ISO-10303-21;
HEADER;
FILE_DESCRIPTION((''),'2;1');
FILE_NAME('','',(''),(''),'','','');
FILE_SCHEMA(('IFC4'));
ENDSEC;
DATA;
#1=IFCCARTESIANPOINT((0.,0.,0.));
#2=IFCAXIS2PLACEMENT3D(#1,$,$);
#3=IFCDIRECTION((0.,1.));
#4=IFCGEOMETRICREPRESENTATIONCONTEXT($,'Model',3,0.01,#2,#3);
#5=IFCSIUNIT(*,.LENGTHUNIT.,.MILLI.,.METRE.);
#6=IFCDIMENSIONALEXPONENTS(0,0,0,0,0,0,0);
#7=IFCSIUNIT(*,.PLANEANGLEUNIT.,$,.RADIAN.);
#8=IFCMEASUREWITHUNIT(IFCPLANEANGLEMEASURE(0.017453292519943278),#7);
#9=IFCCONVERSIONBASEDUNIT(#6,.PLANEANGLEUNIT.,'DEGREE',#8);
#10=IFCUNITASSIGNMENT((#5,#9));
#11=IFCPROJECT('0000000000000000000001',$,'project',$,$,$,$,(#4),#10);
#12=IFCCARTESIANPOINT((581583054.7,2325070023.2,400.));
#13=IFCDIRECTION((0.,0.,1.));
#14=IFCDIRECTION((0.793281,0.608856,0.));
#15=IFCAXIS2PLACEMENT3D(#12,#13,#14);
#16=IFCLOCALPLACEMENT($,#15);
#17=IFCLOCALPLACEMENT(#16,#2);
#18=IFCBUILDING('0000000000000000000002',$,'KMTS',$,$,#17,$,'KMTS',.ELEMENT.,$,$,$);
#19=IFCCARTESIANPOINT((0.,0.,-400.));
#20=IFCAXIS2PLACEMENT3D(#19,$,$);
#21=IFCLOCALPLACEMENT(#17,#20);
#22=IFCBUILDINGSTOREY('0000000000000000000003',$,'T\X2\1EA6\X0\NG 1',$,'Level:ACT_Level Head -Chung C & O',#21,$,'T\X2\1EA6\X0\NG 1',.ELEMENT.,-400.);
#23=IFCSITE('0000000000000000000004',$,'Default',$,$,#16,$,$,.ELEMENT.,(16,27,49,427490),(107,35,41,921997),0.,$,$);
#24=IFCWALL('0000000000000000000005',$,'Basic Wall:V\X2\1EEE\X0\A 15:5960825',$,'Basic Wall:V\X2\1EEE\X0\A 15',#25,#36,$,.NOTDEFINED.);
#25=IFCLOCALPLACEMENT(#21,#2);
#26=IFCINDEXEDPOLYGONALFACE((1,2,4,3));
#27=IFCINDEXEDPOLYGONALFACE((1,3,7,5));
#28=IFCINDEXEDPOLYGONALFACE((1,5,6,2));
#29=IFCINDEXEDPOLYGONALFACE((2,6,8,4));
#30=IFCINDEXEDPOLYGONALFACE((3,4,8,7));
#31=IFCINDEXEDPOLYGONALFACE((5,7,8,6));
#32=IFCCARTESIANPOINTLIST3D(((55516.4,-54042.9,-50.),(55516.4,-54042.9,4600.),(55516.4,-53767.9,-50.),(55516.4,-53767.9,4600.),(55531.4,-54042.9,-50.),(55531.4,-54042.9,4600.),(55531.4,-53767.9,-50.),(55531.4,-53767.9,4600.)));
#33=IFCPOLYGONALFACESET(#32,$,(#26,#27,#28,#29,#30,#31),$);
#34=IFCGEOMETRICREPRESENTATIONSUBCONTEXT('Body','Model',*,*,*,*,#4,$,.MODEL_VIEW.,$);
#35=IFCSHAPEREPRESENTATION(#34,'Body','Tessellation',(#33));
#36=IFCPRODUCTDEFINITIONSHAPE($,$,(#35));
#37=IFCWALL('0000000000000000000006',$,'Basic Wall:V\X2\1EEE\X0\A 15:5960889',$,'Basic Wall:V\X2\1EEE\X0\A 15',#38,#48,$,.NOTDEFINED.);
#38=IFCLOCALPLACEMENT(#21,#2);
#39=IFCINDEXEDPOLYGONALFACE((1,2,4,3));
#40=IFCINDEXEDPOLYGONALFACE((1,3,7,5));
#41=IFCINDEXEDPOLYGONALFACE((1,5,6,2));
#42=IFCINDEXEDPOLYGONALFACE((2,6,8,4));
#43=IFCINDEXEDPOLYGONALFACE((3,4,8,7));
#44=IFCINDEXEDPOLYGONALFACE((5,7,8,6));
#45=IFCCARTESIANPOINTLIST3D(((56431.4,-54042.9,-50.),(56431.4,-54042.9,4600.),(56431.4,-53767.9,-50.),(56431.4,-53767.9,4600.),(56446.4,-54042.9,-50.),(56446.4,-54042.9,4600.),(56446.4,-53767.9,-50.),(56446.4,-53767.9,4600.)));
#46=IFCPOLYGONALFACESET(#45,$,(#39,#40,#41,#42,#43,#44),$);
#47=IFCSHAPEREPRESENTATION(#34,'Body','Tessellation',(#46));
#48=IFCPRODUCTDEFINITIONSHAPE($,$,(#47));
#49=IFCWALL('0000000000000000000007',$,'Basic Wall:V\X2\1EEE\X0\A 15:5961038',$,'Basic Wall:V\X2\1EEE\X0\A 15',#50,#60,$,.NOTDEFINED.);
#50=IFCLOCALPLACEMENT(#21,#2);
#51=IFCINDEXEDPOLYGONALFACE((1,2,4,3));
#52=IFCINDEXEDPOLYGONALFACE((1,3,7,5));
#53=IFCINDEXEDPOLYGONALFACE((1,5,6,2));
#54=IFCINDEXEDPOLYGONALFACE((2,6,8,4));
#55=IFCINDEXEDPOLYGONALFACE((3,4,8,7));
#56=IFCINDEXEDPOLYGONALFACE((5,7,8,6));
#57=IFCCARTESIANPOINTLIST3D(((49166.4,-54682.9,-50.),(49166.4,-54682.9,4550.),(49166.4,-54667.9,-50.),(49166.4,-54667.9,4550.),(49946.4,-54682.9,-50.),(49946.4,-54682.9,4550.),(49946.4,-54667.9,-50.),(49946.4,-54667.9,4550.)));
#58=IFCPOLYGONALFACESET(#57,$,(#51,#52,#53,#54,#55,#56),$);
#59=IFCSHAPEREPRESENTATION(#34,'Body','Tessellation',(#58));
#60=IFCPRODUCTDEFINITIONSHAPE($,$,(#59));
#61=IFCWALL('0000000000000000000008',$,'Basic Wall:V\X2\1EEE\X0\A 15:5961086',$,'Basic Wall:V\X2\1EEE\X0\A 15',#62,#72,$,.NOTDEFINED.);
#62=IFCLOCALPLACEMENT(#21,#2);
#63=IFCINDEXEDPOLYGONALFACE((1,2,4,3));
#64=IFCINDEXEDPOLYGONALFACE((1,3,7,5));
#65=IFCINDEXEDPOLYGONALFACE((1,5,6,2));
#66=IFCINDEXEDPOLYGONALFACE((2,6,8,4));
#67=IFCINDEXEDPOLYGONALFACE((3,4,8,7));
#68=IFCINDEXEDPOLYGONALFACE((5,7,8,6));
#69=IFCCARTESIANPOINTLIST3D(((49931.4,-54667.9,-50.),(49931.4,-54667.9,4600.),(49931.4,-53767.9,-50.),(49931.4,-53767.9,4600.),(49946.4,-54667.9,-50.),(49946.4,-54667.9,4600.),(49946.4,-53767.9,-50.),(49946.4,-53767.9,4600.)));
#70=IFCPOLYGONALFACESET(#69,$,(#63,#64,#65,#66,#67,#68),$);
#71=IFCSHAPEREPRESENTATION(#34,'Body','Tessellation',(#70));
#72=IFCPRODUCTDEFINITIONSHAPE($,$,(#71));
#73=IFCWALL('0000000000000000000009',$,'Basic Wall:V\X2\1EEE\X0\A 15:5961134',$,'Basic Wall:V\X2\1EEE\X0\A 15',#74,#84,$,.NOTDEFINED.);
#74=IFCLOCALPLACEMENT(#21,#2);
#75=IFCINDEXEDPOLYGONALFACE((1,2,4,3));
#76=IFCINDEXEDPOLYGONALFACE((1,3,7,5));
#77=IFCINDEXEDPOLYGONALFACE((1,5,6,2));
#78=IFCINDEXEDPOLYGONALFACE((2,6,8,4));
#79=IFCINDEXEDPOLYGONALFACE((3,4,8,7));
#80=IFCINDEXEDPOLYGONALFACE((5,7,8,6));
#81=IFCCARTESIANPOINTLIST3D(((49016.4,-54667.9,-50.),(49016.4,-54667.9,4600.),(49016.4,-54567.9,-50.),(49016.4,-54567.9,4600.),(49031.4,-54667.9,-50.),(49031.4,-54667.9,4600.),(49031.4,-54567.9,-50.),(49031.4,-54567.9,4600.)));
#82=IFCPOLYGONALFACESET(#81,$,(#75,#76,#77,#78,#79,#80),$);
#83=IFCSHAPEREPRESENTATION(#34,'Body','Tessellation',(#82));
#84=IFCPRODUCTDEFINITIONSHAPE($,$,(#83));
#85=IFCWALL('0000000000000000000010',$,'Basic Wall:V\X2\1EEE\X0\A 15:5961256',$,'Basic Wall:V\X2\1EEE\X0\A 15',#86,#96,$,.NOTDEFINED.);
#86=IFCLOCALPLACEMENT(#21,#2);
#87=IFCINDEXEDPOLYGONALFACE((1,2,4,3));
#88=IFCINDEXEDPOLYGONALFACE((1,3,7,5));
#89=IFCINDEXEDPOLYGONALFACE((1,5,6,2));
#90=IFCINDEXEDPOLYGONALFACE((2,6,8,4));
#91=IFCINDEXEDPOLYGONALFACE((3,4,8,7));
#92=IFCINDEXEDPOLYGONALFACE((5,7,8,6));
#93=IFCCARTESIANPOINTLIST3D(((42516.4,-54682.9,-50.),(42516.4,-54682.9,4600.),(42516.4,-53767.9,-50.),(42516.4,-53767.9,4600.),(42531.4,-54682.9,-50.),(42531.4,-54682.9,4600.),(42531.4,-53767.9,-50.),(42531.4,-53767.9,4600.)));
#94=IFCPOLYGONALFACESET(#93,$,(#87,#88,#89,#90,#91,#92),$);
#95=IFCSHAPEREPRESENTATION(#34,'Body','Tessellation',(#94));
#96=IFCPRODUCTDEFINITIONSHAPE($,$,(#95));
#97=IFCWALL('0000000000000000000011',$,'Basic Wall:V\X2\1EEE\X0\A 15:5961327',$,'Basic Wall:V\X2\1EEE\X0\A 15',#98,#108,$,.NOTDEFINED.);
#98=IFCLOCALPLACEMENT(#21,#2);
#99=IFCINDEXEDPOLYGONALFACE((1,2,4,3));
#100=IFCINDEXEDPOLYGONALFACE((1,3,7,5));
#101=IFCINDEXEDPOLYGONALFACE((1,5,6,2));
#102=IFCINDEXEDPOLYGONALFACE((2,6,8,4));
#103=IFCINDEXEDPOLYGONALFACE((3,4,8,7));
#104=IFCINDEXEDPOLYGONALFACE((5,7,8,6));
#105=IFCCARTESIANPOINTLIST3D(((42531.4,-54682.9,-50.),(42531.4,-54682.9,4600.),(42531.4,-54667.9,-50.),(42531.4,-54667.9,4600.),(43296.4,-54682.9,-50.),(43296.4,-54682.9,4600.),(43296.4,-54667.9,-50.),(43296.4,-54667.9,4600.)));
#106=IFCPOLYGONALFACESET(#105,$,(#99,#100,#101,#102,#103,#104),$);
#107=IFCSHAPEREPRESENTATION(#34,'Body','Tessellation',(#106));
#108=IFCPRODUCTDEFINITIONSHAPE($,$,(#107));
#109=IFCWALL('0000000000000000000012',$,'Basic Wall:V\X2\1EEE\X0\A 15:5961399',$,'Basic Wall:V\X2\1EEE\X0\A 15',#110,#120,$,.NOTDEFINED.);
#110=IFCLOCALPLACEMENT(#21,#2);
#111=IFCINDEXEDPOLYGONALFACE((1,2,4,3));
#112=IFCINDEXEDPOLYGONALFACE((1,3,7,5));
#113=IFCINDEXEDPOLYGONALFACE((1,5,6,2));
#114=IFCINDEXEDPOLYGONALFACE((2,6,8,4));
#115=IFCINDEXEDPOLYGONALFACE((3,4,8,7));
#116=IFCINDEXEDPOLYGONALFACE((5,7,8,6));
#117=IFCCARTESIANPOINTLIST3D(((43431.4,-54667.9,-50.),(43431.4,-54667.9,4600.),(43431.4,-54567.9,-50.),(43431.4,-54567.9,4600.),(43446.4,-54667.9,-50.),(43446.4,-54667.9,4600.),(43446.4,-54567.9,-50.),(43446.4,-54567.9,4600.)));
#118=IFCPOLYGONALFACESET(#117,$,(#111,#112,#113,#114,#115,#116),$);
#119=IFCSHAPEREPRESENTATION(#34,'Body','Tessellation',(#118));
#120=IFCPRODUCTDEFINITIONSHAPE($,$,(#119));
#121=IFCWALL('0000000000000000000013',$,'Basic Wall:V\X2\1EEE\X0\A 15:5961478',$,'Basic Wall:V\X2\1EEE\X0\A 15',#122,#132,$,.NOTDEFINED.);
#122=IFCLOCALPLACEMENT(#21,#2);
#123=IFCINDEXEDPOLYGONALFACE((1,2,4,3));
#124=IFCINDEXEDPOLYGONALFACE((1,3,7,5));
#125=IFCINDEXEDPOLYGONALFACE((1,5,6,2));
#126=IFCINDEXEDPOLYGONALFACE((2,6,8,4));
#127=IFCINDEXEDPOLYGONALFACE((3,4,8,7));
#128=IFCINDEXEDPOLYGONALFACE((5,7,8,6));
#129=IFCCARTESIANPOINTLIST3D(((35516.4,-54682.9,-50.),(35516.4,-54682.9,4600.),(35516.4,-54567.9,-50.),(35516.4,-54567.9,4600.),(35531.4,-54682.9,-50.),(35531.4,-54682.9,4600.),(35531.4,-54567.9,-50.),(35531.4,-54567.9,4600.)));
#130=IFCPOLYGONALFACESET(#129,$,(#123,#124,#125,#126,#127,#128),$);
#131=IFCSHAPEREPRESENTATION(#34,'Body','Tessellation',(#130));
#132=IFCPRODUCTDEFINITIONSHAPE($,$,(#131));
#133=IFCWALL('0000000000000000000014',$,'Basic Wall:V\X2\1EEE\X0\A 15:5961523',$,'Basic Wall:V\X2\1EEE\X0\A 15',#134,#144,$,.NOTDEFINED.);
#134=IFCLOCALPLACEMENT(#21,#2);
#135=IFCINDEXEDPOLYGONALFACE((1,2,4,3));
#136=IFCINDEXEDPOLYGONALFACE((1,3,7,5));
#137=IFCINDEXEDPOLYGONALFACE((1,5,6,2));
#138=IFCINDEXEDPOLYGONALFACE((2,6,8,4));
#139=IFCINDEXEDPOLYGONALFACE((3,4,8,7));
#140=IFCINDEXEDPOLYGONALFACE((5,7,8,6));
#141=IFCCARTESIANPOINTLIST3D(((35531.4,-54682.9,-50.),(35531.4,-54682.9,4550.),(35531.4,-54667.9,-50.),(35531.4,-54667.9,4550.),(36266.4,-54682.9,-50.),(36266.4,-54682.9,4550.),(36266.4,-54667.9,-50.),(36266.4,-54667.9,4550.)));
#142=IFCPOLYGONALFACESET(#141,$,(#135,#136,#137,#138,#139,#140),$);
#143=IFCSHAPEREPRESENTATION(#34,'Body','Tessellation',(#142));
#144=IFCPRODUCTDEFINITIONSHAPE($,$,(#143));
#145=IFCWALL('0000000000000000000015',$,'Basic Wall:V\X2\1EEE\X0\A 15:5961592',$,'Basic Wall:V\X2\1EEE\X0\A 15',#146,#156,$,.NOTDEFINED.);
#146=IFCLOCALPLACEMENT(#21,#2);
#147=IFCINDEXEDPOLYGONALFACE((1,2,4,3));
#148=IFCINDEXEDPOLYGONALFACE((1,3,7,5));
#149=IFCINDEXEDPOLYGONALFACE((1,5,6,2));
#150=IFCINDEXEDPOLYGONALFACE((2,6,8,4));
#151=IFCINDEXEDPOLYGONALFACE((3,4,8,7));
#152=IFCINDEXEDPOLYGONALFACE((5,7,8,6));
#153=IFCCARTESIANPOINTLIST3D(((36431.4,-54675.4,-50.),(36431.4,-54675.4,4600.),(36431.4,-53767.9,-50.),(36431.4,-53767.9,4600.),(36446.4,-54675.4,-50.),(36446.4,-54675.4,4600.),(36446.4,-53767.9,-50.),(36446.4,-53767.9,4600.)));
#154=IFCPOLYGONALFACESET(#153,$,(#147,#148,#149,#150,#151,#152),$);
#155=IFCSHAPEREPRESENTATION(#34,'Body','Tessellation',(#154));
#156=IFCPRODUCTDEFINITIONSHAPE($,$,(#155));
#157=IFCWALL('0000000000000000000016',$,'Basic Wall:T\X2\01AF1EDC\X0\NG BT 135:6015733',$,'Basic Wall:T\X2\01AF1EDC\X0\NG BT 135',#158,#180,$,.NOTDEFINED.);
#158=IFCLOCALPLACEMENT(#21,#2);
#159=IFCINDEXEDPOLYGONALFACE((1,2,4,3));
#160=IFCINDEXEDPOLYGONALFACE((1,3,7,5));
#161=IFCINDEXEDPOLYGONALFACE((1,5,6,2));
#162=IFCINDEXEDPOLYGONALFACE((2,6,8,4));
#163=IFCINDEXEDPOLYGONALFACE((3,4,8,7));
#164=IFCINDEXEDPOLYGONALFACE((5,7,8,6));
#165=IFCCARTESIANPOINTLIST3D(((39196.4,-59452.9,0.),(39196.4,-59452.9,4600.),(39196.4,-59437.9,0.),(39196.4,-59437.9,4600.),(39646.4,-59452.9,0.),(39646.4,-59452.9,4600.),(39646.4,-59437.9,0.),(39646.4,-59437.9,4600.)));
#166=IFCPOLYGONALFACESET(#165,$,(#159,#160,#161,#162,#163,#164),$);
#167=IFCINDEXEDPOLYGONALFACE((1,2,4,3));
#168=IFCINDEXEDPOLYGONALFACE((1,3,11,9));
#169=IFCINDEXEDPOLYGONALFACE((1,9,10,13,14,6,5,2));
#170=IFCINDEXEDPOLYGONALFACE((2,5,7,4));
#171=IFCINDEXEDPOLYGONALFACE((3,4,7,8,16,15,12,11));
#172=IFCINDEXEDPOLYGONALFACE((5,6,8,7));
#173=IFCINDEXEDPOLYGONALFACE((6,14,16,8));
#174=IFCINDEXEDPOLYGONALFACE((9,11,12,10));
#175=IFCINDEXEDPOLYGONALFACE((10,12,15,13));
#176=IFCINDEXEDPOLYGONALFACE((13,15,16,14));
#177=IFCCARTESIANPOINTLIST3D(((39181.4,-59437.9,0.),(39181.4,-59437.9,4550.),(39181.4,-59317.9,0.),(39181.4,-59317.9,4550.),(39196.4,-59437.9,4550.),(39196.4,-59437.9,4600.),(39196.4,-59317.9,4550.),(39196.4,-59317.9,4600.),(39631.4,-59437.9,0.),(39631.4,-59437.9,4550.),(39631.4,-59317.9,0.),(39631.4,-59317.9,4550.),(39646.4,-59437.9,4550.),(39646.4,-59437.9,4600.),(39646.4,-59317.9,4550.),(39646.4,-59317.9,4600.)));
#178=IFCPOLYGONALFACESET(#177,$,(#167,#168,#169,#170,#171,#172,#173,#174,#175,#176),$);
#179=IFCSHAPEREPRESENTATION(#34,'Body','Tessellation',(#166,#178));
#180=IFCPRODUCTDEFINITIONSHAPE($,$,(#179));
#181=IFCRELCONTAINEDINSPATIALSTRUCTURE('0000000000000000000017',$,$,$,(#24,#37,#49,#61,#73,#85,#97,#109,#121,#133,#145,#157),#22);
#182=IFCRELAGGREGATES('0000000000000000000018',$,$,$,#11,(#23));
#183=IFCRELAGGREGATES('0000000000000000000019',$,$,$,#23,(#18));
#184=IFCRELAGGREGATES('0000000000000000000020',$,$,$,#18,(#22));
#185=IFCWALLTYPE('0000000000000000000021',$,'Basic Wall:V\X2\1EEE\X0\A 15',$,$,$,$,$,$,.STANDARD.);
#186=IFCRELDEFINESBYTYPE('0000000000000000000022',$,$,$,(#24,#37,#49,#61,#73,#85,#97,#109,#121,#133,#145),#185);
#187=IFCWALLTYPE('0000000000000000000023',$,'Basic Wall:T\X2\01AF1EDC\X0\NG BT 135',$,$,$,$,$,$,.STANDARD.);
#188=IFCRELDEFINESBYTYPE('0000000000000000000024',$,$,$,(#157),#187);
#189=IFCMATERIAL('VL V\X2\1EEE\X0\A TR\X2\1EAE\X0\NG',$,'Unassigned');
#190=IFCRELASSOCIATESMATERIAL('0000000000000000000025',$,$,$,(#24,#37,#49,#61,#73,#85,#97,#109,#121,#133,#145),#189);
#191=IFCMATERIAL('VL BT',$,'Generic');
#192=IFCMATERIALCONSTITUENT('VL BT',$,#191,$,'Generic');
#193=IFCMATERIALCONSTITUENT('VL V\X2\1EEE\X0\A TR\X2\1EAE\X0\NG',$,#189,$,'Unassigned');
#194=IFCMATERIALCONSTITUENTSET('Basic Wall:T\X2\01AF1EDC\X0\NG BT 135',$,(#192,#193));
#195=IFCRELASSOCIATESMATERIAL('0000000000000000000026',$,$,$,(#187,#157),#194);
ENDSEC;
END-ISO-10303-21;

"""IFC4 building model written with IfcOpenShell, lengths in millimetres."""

from ifc_helpers import new_model, entity, si_unit, converted_unit, direction, frame, origin, place, context, subcontext, project, spatial, indexed_curve, outline, extrude, material, constituent, constituent_set, type_object, element, save


model = new_model("IFC4")

# Units and contexts
model_context = context("Model", 3, precision=0.01, world=origin(), true_north=direction((0.0, 1.0)))
body_context = subcontext(model_context, "Body", "Model", "MODEL_VIEW")
ifc_project = project(units=[si_unit("LENGTHUNIT", "METRE", prefix="MILLI"), converted_unit("PLANEANGLEUNIT", "DEGREE", entity("IfcPlaneAngleMeasure", 0.017453292519943278), si_unit("PLANEANGLEUNIT", "RADIAN"), dimensions=[0, 0, 0, 0, 0, 0, 0])], contexts=[model_context])

# Site, building, storey
site_placement = place(None, frame((581583054.7, 2325070023.2, 400.0), z_axis=(0.0, 0.0, 1.0), x_axis=(0.793281, 0.608856, 0.0)))
site = spatial("IfcSite", under=ifc_project, at=site_placement, Name="Default", CompositionType="ELEMENT", RefLatitude=(16, 27, 49, 427490), RefLongitude=(107, 35, 41, 921997), RefElevation=0.0)
building_placement = place(site_placement, origin())
building = spatial("IfcBuilding", under=site, at=building_placement, Name="KMTS", LongName="KMTS", CompositionType="ELEMENT")
storey_placement = place(building_placement, frame((0.0, 0.0, -400.0)))
storey = spatial("IfcBuildingStorey", under=building, at=storey_placement, Name="TẦNG 1", ObjectType="Level:ACT_Level Head -Chung C & O", LongName="TẦNG 1", CompositionType="ELEMENT", Elevation=-400.0)

# Shared definitions
ifc_material_1 = material(Name="VL VỮA TRẮNG", Category="Unassigned")
ifc_material_2 = material(Name="VL BT", Category="Generic")

# Walls
wall_type_1 = type_object("IfcWallType", Name="Basic Wall:VỮA 15", PredefinedType="STANDARD")
wall_1_placement = place(storey_placement, frame((55523.9, -54042.9, -50.0), z_axis=(0.0, 0.0, 1.0), x_axis=(0.0, 1.0, 0.0)))
element("IfcWall", 1, at=wall_1_placement, inside=storey, type_object=wall_type_1, material=ifc_material_1, Name="Basic Wall:VỮA 15:5960825", ObjectType="Basic Wall:VỮA 15", PredefinedType="NOTDEFINED", context=body_context, shape_type="SweptSolid", body=[
    extrude(outline(indexed_curve([(275.0, 7.5), (0.0, 7.5), (0.0, -7.5), (275.0, -7.5), (275.0, 7.5)], self_intersect=False)), origin(), (0.0, 0.0, 1.0), 4650.0),
])
wall_2_placement = place(storey_placement, frame((56438.9, -54042.9, -50.0), z_axis=(0.0, 0.0, 1.0), x_axis=(0.0, 1.0, 0.0)))
element("IfcWall", 2, at=wall_2_placement, inside=storey, type_object=wall_type_1, material=ifc_material_1, Name="Basic Wall:VỮA 15:5960889", ObjectType="Basic Wall:VỮA 15", PredefinedType="NOTDEFINED", context=body_context, shape_type="SweptSolid", body=[
    extrude(outline(indexed_curve([(275.0, 7.5), (0.0, 7.5), (0.0, -7.5), (275.0, -7.5), (275.0, 7.5)], self_intersect=False)), origin(), (0.0, 0.0, 1.0), 4650.0),
])
wall_3_placement = place(storey_placement, frame((49166.4, -54675.4, -50.0)))
element("IfcWall", 3, at=wall_3_placement, inside=storey, type_object=wall_type_1, material=ifc_material_1, Name="Basic Wall:VỮA 15:5961038", ObjectType="Basic Wall:VỮA 15", PredefinedType="NOTDEFINED", context=body_context, shape_type="SweptSolid", body=[
    extrude(outline(indexed_curve([(780.0, 7.5), (0.0, 7.5), (0.0, -7.5), (780.0, -7.5), (780.0, 7.5)], self_intersect=False)), origin(), (0.0, 0.0, 1.0), 4600.0),
])
wall_4_placement = place(storey_placement, frame((49938.9, -54667.9, -50.0), z_axis=(0.0, 0.0, 1.0), x_axis=(0.0, 1.0, 0.0)))
element("IfcWall", 4, at=wall_4_placement, inside=storey, type_object=wall_type_1, material=ifc_material_1, Name="Basic Wall:VỮA 15:5961086", ObjectType="Basic Wall:VỮA 15", PredefinedType="NOTDEFINED", context=body_context, shape_type="SweptSolid", body=[
    extrude(outline(indexed_curve([(900.0, 7.5), (0.0, 7.5), (0.0, -7.5), (900.0, -7.5), (900.0, 7.5)], self_intersect=False)), origin(), (0.0, 0.0, 1.0), 4650.0),
])
wall_5_placement = place(storey_placement, frame((49023.9, -54667.9, -50.0), z_axis=(0.0, 0.0, 1.0), x_axis=(0.0, 1.0, 0.0)))
element("IfcWall", 5, at=wall_5_placement, inside=storey, type_object=wall_type_1, material=ifc_material_1, Name="Basic Wall:VỮA 15:5961134", ObjectType="Basic Wall:VỮA 15", PredefinedType="NOTDEFINED", context=body_context, shape_type="SweptSolid", body=[
    extrude(outline(indexed_curve([(100.0, 7.5), (0.0, 7.5), (0.0, -7.5), (100.0, -7.5), (100.0, 7.5)], self_intersect=False)), origin(), (0.0, 0.0, 1.0), 4650.0),
])
wall_6_placement = place(storey_placement, frame((42523.9, -53767.9, -50.0), z_axis=(0.0, 0.0, 1.0), x_axis=(0.0, -1.0, 0.0)))
element("IfcWall", 6, at=wall_6_placement, inside=storey, type_object=wall_type_1, material=ifc_material_1, Name="Basic Wall:VỮA 15:5961256", ObjectType="Basic Wall:VỮA 15", PredefinedType="NOTDEFINED", context=body_context, shape_type="SweptSolid", body=[
    extrude(outline(indexed_curve([(915.0, 7.5), (0.0, 7.5), (0.0, -7.5), (915.0, -7.5), (915.0, 7.5)], self_intersect=False)), origin(), (0.0, 0.0, 1.0), 4650.0),
])
wall_7_placement = place(storey_placement, frame((42531.4, -54675.4, -50.0)))
element("IfcWall", 7, at=wall_7_placement, inside=storey, type_object=wall_type_1, material=ifc_material_1, Name="Basic Wall:VỮA 15:5961327", ObjectType="Basic Wall:VỮA 15", PredefinedType="NOTDEFINED", context=body_context, shape_type="SweptSolid", body=[
    extrude(outline(indexed_curve([(765.0, 7.5), (0.0, 7.5), (0.0, -7.5), (765.0, -7.5), (765.0, 7.5)], self_intersect=False)), origin(), (0.0, 0.0, 1.0), 4650.0),
])
wall_8_placement = place(storey_placement, frame((43438.9, -54667.9, -50.0), z_axis=(0.0, 0.0, 1.0), x_axis=(0.0, 1.0, 0.0)))
element("IfcWall", 8, at=wall_8_placement, inside=storey, type_object=wall_type_1, material=ifc_material_1, Name="Basic Wall:VỮA 15:5961399", ObjectType="Basic Wall:VỮA 15", PredefinedType="NOTDEFINED", context=body_context, shape_type="SweptSolid", body=[
    extrude(outline(indexed_curve([(100.0, 7.5), (0.0, 7.5), (0.0, -7.5), (100.0, -7.5), (100.0, 7.5)], self_intersect=False)), origin(), (0.0, 0.0, 1.0), 4650.0),
])
wall_9_placement = place(storey_placement, frame((35523.9, -54567.9, -50.0), z_axis=(0.0, 0.0, 1.0), x_axis=(0.0, -1.0, 0.0)))
element("IfcWall", 9, at=wall_9_placement, inside=storey, type_object=wall_type_1, material=ifc_material_1, Name="Basic Wall:VỮA 15:5961478", ObjectType="Basic Wall:VỮA 15", PredefinedType="NOTDEFINED", context=body_context, shape_type="SweptSolid", body=[
    extrude(outline(indexed_curve([(115.0, 7.5), (0.0, 7.5), (0.0, -7.5), (115.0, -7.5), (115.0, 7.5)], self_intersect=False)), origin(), (0.0, 0.0, 1.0), 4650.0),
])
wall_10_placement = place(storey_placement, frame((35531.4, -54675.4, -50.0)))
element("IfcWall", 10, at=wall_10_placement, inside=storey, type_object=wall_type_1, material=ifc_material_1, Name="Basic Wall:VỮA 15:5961523", ObjectType="Basic Wall:VỮA 15", PredefinedType="NOTDEFINED", context=body_context, shape_type="SweptSolid", body=[
    extrude(outline(indexed_curve([(735.0, 7.5), (0.0, 7.5), (0.0, -7.5), (735.0, -7.5), (735.0, 7.5)], self_intersect=False)), origin(), (0.0, 0.0, 1.0), 4600.0),
])
wall_11_placement = place(storey_placement, frame((36438.9, -54675.4, -50.0), z_axis=(0.0, 0.0, 1.0), x_axis=(0.0, 1.0, 0.0)))
element("IfcWall", 11, at=wall_11_placement, inside=storey, type_object=wall_type_1, material=ifc_material_1, Name="Basic Wall:VỮA 15:5961592", ObjectType="Basic Wall:VỮA 15", PredefinedType="NOTDEFINED", context=body_context, shape_type="SweptSolid", body=[
    extrude(outline(indexed_curve([(907.5, 7.5), (0.0, 7.5), (0.0, -7.5), (907.5, -7.5), (907.5, 7.5)], self_intersect=False)), origin(), (0.0, 0.0, 1.0), 4650.0),
])
ifc_constituent_1 = constituent(ifc_material_2, Name="VL BT", Category="Generic")
ifc_constituent_2 = constituent(ifc_material_1, Name="VL VỮA TRẮNG", Category="Unassigned")
ifc_constituent_set_1 = constituent_set(constituents=[ifc_constituent_1, ifc_constituent_2], Name="Basic Wall:TƯỜNG BT 135")
wall_type_2 = type_object("IfcWallType", Name="Basic Wall:TƯỜNG BT 135", PredefinedType="STANDARD", material=ifc_constituent_set_1)
wall_12_placement = place(storey_placement, frame((39196.4, -59385.4, 0.0)))
element("IfcWall", 12, at=wall_12_placement, inside=storey, type_object=wall_type_2, material=ifc_constituent_set_1, Name="Basic Wall:TƯỜNG BT 135:6015733", ObjectType="Basic Wall:TƯỜNG BT 135", PredefinedType="NOTDEFINED", context=body_context, shape_type="SweptSolid", body=[
    extrude(outline(indexed_curve([(-7.5, -225.0), (7.5, -225.0), (7.5, 225.0), (-7.5, 225.0), (-7.5, -225.0)], self_intersect=False)), frame((225.0, -60.0, 0.0), z_axis=(0.0, 0.0, 1.0), x_axis=(0.0, 1.0, 0.0)), (0.0, 0.0, 1.0), 4600.0),
    extrude(outline(indexed_curve([(-3425.0, -232.5), (1125.0, -232.5), (1125.0, -217.5), (1175.0, -217.5), (1175.0, 232.5), (1125.0, 232.5), (1125.0, 217.5), (-3425.0, 217.5), (-3425.0, -232.5)], self_intersect=False)), frame((217.5, -52.5, 3425.0), z_axis=(0.0, 1.0, 0.0), x_axis=(0.0, 0.0, 1.0)), (0.0, 0.0, 1.0), 120.0),
])

save(model, "model.ifc")
